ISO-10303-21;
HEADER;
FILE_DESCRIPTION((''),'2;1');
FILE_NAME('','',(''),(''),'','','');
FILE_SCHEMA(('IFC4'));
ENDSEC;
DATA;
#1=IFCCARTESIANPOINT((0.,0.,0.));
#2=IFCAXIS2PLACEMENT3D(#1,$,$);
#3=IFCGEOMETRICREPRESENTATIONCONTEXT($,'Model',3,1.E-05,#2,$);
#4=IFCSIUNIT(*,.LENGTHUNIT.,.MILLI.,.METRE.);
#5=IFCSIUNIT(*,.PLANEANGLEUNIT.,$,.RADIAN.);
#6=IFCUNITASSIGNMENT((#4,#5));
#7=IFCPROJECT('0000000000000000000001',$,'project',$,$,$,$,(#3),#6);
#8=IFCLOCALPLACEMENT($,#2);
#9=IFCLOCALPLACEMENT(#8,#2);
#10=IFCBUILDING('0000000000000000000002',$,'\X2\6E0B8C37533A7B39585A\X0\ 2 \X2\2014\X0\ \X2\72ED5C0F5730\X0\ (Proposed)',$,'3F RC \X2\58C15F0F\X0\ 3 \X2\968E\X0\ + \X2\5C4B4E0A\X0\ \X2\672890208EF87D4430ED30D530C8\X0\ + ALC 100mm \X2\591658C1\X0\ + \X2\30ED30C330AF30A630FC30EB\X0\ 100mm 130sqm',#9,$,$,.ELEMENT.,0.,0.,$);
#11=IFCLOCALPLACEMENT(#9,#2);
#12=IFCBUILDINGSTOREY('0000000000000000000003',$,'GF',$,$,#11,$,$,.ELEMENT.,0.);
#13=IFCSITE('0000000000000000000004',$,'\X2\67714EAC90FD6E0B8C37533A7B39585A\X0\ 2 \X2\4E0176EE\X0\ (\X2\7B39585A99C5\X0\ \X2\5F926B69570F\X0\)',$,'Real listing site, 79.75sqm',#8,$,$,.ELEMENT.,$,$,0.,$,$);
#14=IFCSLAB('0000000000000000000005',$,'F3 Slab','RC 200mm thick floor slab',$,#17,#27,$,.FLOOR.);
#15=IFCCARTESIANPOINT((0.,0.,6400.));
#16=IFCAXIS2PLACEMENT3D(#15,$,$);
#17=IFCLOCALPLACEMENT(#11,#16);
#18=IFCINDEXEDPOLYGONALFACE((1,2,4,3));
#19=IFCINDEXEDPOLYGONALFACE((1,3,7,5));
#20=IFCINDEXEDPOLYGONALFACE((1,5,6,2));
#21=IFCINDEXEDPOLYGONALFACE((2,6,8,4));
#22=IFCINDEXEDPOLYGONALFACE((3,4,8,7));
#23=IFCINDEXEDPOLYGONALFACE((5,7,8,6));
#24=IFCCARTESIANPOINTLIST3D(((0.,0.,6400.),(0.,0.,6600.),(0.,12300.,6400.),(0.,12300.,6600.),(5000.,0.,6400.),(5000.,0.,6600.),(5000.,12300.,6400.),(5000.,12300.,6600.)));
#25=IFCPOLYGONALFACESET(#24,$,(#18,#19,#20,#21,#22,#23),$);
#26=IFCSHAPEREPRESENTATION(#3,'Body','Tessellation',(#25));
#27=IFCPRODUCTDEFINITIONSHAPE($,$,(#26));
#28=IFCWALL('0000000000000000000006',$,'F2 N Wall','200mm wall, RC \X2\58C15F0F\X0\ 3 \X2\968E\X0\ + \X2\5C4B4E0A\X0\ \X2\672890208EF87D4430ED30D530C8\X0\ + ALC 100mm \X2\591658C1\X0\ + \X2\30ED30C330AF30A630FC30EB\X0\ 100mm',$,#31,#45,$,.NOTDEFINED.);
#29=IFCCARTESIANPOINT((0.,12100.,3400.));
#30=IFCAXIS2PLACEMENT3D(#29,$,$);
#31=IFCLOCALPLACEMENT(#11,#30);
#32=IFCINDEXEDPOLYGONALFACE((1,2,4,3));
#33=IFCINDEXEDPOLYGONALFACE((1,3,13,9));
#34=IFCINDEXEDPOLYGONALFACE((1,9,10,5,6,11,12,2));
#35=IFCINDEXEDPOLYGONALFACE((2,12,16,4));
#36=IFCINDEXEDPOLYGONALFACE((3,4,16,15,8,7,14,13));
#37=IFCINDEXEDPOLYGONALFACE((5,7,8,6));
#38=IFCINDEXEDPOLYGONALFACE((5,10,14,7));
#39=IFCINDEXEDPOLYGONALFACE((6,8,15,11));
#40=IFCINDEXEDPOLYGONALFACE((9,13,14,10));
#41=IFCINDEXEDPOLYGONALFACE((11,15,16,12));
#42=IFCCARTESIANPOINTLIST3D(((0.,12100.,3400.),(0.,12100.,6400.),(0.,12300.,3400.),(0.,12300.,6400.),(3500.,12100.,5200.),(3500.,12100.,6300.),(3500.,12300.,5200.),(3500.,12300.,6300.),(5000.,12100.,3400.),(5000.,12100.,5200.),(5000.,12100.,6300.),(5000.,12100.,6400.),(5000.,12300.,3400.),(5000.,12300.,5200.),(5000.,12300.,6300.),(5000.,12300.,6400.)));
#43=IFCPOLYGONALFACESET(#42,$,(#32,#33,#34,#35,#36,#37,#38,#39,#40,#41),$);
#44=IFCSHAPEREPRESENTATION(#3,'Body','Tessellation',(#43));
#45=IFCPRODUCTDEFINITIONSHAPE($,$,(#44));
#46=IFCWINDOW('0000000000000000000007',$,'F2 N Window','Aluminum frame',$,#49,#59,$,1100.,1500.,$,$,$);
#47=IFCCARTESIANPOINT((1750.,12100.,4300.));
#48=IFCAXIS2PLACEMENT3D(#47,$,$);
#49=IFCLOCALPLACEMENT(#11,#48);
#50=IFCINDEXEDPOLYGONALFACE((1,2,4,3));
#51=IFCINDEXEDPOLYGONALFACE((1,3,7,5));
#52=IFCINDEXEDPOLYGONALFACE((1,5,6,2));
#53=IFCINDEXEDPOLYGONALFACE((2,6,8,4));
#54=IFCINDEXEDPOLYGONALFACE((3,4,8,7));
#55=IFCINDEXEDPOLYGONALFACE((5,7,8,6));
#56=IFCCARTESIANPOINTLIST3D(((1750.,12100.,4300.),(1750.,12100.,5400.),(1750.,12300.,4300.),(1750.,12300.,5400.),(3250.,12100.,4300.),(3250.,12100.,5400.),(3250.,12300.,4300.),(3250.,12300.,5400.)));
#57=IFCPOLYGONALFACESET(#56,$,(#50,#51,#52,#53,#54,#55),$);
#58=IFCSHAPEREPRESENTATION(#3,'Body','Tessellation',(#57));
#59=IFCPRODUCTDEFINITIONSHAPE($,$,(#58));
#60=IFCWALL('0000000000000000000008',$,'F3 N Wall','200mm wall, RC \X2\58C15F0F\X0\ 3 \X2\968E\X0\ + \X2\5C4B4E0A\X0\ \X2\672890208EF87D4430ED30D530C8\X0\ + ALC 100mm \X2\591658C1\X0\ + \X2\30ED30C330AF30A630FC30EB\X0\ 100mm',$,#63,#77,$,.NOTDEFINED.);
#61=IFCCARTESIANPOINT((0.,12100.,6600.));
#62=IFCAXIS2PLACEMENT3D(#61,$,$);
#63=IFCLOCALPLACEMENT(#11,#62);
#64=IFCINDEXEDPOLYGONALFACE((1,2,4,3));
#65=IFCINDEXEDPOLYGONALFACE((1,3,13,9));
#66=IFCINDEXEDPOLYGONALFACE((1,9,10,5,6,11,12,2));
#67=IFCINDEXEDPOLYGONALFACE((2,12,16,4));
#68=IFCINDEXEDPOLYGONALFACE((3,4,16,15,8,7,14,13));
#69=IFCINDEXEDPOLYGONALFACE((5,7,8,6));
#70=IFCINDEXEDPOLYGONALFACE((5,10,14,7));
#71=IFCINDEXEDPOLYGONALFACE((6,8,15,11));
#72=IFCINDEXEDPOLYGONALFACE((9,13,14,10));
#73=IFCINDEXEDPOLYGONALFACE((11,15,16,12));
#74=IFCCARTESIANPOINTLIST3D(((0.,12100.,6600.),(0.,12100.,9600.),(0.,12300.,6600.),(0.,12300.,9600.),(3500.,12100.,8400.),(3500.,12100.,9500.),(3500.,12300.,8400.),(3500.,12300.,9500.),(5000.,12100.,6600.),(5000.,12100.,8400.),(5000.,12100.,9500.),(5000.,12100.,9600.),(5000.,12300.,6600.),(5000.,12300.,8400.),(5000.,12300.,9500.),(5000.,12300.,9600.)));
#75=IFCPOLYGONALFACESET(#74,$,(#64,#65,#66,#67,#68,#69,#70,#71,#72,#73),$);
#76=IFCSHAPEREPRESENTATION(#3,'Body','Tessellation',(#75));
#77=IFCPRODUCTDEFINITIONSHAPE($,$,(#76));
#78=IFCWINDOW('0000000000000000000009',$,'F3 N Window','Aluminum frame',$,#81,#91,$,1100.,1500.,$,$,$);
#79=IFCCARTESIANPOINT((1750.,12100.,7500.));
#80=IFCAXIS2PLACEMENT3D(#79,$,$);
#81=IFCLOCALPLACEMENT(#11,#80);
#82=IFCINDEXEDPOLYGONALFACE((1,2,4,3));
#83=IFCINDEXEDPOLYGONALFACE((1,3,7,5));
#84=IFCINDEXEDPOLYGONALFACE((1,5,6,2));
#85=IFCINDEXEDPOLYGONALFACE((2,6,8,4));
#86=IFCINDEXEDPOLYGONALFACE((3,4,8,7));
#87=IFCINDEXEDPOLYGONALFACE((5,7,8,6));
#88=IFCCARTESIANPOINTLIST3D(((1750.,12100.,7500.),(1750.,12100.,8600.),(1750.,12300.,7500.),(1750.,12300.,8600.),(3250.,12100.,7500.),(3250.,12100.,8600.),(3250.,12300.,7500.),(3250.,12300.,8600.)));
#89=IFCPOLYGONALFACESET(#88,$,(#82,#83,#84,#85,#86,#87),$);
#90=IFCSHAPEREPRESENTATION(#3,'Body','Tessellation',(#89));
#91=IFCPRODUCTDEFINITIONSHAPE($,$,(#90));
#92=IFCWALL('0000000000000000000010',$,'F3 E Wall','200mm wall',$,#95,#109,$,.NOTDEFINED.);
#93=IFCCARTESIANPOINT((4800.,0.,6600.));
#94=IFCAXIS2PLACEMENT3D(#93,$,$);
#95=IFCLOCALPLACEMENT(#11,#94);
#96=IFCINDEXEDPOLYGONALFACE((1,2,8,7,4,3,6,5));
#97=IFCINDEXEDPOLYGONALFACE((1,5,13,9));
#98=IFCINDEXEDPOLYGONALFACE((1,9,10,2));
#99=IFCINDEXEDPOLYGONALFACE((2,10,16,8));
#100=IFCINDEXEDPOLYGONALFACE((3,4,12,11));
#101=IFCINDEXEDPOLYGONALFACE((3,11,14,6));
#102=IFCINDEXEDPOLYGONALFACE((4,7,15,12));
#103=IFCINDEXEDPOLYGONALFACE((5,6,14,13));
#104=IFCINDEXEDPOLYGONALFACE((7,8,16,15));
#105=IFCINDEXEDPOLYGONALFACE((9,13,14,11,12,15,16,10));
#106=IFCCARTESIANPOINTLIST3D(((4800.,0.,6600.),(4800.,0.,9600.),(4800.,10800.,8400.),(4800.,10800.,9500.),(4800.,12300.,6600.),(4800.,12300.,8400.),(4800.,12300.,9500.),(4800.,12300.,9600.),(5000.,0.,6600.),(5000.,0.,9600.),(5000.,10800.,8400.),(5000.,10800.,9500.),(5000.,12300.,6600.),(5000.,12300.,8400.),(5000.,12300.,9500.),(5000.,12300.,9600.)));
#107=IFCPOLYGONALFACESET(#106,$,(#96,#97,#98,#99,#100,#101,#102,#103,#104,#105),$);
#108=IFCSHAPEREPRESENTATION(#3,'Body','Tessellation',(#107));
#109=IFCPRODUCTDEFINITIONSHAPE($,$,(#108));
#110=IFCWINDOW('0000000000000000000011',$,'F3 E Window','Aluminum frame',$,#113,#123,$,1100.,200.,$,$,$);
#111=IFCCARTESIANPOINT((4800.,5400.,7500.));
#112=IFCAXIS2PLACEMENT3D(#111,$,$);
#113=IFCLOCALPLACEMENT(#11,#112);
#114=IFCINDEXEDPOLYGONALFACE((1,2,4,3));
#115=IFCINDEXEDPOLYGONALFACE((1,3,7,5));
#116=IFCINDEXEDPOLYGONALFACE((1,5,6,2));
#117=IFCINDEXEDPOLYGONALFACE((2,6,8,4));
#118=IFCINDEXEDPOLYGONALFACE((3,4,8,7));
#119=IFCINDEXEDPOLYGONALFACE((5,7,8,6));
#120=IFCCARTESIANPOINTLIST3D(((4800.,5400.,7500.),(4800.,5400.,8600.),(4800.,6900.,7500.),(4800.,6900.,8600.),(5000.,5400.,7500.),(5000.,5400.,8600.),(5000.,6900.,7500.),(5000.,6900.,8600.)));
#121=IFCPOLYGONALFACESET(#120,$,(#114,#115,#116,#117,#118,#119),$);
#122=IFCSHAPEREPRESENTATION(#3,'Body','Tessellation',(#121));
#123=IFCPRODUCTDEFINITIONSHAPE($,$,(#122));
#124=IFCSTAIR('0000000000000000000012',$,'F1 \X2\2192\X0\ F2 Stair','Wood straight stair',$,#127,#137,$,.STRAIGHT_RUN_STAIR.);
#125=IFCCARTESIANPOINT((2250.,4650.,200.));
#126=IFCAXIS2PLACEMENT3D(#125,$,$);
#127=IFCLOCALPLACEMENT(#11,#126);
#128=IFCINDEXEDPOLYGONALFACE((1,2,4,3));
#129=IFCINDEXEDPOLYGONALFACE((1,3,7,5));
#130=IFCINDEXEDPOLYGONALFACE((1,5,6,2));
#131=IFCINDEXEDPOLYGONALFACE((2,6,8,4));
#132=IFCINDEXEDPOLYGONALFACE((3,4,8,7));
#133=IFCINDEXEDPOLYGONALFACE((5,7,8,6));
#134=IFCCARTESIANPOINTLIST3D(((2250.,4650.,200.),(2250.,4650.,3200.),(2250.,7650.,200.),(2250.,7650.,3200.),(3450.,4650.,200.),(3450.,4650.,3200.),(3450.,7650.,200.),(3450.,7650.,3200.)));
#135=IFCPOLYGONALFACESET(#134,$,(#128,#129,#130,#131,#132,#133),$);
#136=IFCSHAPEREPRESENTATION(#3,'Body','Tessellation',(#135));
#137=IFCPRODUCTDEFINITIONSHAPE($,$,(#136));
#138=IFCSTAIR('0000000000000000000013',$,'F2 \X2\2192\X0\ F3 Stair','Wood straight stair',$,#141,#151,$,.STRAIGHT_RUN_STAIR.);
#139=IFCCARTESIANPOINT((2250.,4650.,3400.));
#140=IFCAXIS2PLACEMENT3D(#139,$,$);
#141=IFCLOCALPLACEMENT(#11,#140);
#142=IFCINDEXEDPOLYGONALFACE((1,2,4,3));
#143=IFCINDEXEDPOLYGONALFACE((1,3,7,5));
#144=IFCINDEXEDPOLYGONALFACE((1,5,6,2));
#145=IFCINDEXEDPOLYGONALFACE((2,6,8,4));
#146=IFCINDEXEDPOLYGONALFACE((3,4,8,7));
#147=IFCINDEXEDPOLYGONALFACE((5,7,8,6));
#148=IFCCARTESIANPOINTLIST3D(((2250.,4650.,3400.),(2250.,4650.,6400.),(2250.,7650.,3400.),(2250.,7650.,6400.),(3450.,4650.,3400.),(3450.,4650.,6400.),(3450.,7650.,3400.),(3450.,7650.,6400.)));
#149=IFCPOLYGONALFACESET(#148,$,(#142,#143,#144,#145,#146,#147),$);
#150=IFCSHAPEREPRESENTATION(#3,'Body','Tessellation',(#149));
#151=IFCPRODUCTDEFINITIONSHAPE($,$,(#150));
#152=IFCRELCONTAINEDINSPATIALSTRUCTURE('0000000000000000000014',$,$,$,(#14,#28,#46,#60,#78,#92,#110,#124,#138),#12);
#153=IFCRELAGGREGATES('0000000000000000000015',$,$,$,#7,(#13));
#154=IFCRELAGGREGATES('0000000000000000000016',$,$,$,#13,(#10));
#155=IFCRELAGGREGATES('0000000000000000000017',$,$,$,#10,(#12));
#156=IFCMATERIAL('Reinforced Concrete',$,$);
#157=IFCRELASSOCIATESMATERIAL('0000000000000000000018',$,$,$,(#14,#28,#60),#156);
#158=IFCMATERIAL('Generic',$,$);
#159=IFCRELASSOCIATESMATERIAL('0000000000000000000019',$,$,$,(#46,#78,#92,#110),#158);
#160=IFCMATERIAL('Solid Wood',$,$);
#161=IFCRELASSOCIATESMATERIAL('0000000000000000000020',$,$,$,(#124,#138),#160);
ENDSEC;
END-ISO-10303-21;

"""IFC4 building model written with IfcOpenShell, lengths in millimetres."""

from ifc_helpers import new_model, si_unit, frame, frame_2d, origin, place, context, project, spatial, rectangle, extrude, material, element, fill, save


model = new_model("IFC4")

# Units and contexts
model_context = context("Model", 3, precision=1e-05, world=origin())
ifc_project = project(units=[si_unit("LENGTHUNIT", "METRE", prefix="MILLI"), si_unit("PLANEANGLEUNIT", "RADIAN")], contexts=[model_context])

# Site, building, storey
site_placement = place(None, origin())
site = spatial("IfcSite", under=ifc_project, at=site_placement, Name="東京都渋谷区笹塚 2 丁目 (笹塚駅 徒歩圏)", ObjectType="Real listing site, 79.75sqm", CompositionType="ELEMENT", RefElevation=0.0)
building_placement = place(site_placement, origin())
building = spatial("IfcBuilding", under=site, at=building_placement, Name="渋谷区笹塚 2 — 狭小地 (Proposed)", ObjectType="3F RC 壁式 3 階 + 屋上 木造軸組ロフト + ALC 100mm 外壁 + ロックウール 100mm 130sqm", CompositionType="ELEMENT", ElevationOfRefHeight=0.0, ElevationOfTerrain=0.0)
storey_placement = place(building_placement, origin())
storey = spatial("IfcBuildingStorey", under=building, at=storey_placement, Name="GF", CompositionType="ELEMENT", Elevation=0.0)

# Slab
ifc_material_1 = material(Name="Reinforced Concrete")
slab_placement = place(storey_placement, frame((0.0, 0.0, 6400.0)))
element("IfcSlab", 1, at=slab_placement, inside=storey, material=ifc_material_1, Name="F3 Slab", Description="RC 200mm thick floor slab", PredefinedType="FLOOR", context=model_context, shape_type="SweptSolid", body=[
    extrude(rectangle(XDim=5000.0, YDim=12300.0, at=frame_2d((2500.0, 6150.0))), frame((0.0, 0.0, 6400.0)), (0.0, 0.0, 1.0), 200.0),
])

# Walls, openings, windows
ifc_material_2 = material(Name="Generic")
wall_1_placement = place(storey_placement, frame((0.0, 12100.0, 3400.0)))
wall_1 = element("IfcWall", 2, at=wall_1_placement, inside=storey, material=ifc_material_1, Name="F2 N Wall", Description="200mm wall, RC 壁式 3 階 + 屋上 木造軸組ロフト + ALC 100mm 外壁 + ロックウール 100mm", PredefinedType="NOTDEFINED", context=model_context, shape_type="SweptSolid", body=[
    extrude(rectangle(XDim=5000.0, YDim=200.0, at=frame_2d((2500.0, 100.0))), frame((0.0, 12100.0, 3400.0)), (0.0, 0.0, 1.0), 3000.0),
])
opening_1_placement = place(storey_placement, frame((1750.0, 12100.0, 4300.0)))
opening_1 = element("IfcOpeningElement", 3, at=opening_1_placement, cuts=wall_1, PredefinedType="NOTDEFINED", context=model_context, shape_type="SweptSolid", body=[
    extrude(rectangle(XDim=1500.0, YDim=200.0, at=frame_2d((750.0, 100.0))), frame((1750.0, 12100.0, 4300.0)), (0.0, 0.0, 1.0), 1100.0),
])
window_1_placement = place(storey_placement, frame((1750.0, 12100.0, 4300.0)))
window_1 = element("IfcWindow", 4, at=window_1_placement, inside=storey, material=ifc_material_2, Name="F2 N Window", Description="Aluminum frame", OverallHeight=1100.0, OverallWidth=1500.0, context=model_context, shape_type="SweptSolid", body=[
    extrude(rectangle(XDim=1500.0, YDim=200.0, at=frame_2d((750.0, 100.0))), frame((1750.0, 12100.0, 4300.0)), (0.0, 0.0, 1.0), 1100.0),
])
fill(opening_1, window_1)
wall_2_placement = place(storey_placement, frame((0.0, 12100.0, 6600.0)))
wall_2 = element("IfcWall", 5, at=wall_2_placement, inside=storey, material=ifc_material_1, Name="F3 N Wall", Description="200mm wall, RC 壁式 3 階 + 屋上 木造軸組ロフト + ALC 100mm 外壁 + ロックウール 100mm", PredefinedType="NOTDEFINED", context=model_context, shape_type="SweptSolid", body=[
    extrude(rectangle(XDim=5000.0, YDim=200.0, at=frame_2d((2500.0, 100.0))), frame((0.0, 12100.0, 6600.0)), (0.0, 0.0, 1.0), 3000.0),
])
opening_2_placement = place(storey_placement, frame((1750.0, 12100.0, 7500.0)))
opening_2 = element("IfcOpeningElement", 6, at=opening_2_placement, cuts=wall_2, PredefinedType="NOTDEFINED", context=model_context, shape_type="SweptSolid", body=[
    extrude(rectangle(XDim=1500.0, YDim=200.0, at=frame_2d((750.0, 100.0))), frame((1750.0, 12100.0, 7500.0)), (0.0, 0.0, 1.0), 1100.0),
])
window_2_placement = place(storey_placement, frame((1750.0, 12100.0, 7500.0)))
window_2 = element("IfcWindow", 7, at=window_2_placement, inside=storey, material=ifc_material_2, Name="F3 N Window", Description="Aluminum frame", OverallHeight=1100.0, OverallWidth=1500.0, context=model_context, shape_type="SweptSolid", body=[
    extrude(rectangle(XDim=1500.0, YDim=200.0, at=frame_2d((750.0, 100.0))), frame((1750.0, 12100.0, 7500.0)), (0.0, 0.0, 1.0), 1100.0),
])
fill(opening_2, window_2)
wall_3_placement = place(storey_placement, frame((4800.0, 0.0, 6600.0)))
wall_3 = element("IfcWall", 8, at=wall_3_placement, inside=storey, material=ifc_material_2, Name="F3 E Wall", Description="200mm wall", PredefinedType="NOTDEFINED", context=model_context, shape_type="SweptSolid", body=[
    extrude(rectangle(XDim=200.0, YDim=12300.0, at=frame_2d((100.0, 6150.0))), frame((4800.0, 0.0, 6600.0)), (0.0, 0.0, 1.0), 3000.0),
])
opening_3_placement = place(storey_placement, frame((4800.0, 5400.0, 7500.0)))
opening_3 = element("IfcOpeningElement", 9, at=opening_3_placement, cuts=wall_3, PredefinedType="NOTDEFINED", context=model_context, shape_type="SweptSolid", body=[
    extrude(rectangle(XDim=200.0, YDim=1500.0, at=frame_2d((100.0, 750.0))), frame((4800.0, 5400.0, 7500.0)), (0.0, 0.0, 1.0), 1100.0),
])
window_3_placement = place(storey_placement, frame((4800.0, 5400.0, 7500.0)))
window_3 = element("IfcWindow", 10, at=window_3_placement, inside=storey, material=ifc_material_2, Name="F3 E Window", Description="Aluminum frame", OverallHeight=1100.0, OverallWidth=200.0, context=model_context, shape_type="SweptSolid", body=[
    extrude(rectangle(XDim=200.0, YDim=1500.0, at=frame_2d((100.0, 750.0))), frame((4800.0, 5400.0, 7500.0)), (0.0, 0.0, 1.0), 1100.0),
])
fill(opening_3, window_3)

# Stairs
ifc_material_3 = material(Name="Solid Wood")
stair_1_placement = place(storey_placement, frame((2250.0, 4650.0, 200.0)))
element("IfcStair", 11, at=stair_1_placement, inside=storey, material=ifc_material_3, Name="F1 → F2 Stair", Description="Wood straight stair", PredefinedType="STRAIGHT_RUN_STAIR", context=model_context, shape_type="SweptSolid", body=[
    extrude(rectangle(XDim=1200.0, YDim=3000.0, at=frame_2d((600.0, 1500.0))), frame((2250.0, 4650.0, 200.0)), (0.0, 0.0, 1.0), 3000.0),
])
stair_2_placement = place(storey_placement, frame((2250.0, 4650.0, 3400.0)))
element("IfcStair", 12, at=stair_2_placement, inside=storey, material=ifc_material_3, Name="F2 → F3 Stair", Description="Wood straight stair", PredefinedType="STRAIGHT_RUN_STAIR", context=model_context, shape_type="SweptSolid", body=[
    extrude(rectangle(XDim=1200.0, YDim=3000.0, at=frame_2d((600.0, 1500.0))), frame((2250.0, 4650.0, 3400.0)), (0.0, 0.0, 1.0), 3000.0),
])

save(model, "model.ifc")
